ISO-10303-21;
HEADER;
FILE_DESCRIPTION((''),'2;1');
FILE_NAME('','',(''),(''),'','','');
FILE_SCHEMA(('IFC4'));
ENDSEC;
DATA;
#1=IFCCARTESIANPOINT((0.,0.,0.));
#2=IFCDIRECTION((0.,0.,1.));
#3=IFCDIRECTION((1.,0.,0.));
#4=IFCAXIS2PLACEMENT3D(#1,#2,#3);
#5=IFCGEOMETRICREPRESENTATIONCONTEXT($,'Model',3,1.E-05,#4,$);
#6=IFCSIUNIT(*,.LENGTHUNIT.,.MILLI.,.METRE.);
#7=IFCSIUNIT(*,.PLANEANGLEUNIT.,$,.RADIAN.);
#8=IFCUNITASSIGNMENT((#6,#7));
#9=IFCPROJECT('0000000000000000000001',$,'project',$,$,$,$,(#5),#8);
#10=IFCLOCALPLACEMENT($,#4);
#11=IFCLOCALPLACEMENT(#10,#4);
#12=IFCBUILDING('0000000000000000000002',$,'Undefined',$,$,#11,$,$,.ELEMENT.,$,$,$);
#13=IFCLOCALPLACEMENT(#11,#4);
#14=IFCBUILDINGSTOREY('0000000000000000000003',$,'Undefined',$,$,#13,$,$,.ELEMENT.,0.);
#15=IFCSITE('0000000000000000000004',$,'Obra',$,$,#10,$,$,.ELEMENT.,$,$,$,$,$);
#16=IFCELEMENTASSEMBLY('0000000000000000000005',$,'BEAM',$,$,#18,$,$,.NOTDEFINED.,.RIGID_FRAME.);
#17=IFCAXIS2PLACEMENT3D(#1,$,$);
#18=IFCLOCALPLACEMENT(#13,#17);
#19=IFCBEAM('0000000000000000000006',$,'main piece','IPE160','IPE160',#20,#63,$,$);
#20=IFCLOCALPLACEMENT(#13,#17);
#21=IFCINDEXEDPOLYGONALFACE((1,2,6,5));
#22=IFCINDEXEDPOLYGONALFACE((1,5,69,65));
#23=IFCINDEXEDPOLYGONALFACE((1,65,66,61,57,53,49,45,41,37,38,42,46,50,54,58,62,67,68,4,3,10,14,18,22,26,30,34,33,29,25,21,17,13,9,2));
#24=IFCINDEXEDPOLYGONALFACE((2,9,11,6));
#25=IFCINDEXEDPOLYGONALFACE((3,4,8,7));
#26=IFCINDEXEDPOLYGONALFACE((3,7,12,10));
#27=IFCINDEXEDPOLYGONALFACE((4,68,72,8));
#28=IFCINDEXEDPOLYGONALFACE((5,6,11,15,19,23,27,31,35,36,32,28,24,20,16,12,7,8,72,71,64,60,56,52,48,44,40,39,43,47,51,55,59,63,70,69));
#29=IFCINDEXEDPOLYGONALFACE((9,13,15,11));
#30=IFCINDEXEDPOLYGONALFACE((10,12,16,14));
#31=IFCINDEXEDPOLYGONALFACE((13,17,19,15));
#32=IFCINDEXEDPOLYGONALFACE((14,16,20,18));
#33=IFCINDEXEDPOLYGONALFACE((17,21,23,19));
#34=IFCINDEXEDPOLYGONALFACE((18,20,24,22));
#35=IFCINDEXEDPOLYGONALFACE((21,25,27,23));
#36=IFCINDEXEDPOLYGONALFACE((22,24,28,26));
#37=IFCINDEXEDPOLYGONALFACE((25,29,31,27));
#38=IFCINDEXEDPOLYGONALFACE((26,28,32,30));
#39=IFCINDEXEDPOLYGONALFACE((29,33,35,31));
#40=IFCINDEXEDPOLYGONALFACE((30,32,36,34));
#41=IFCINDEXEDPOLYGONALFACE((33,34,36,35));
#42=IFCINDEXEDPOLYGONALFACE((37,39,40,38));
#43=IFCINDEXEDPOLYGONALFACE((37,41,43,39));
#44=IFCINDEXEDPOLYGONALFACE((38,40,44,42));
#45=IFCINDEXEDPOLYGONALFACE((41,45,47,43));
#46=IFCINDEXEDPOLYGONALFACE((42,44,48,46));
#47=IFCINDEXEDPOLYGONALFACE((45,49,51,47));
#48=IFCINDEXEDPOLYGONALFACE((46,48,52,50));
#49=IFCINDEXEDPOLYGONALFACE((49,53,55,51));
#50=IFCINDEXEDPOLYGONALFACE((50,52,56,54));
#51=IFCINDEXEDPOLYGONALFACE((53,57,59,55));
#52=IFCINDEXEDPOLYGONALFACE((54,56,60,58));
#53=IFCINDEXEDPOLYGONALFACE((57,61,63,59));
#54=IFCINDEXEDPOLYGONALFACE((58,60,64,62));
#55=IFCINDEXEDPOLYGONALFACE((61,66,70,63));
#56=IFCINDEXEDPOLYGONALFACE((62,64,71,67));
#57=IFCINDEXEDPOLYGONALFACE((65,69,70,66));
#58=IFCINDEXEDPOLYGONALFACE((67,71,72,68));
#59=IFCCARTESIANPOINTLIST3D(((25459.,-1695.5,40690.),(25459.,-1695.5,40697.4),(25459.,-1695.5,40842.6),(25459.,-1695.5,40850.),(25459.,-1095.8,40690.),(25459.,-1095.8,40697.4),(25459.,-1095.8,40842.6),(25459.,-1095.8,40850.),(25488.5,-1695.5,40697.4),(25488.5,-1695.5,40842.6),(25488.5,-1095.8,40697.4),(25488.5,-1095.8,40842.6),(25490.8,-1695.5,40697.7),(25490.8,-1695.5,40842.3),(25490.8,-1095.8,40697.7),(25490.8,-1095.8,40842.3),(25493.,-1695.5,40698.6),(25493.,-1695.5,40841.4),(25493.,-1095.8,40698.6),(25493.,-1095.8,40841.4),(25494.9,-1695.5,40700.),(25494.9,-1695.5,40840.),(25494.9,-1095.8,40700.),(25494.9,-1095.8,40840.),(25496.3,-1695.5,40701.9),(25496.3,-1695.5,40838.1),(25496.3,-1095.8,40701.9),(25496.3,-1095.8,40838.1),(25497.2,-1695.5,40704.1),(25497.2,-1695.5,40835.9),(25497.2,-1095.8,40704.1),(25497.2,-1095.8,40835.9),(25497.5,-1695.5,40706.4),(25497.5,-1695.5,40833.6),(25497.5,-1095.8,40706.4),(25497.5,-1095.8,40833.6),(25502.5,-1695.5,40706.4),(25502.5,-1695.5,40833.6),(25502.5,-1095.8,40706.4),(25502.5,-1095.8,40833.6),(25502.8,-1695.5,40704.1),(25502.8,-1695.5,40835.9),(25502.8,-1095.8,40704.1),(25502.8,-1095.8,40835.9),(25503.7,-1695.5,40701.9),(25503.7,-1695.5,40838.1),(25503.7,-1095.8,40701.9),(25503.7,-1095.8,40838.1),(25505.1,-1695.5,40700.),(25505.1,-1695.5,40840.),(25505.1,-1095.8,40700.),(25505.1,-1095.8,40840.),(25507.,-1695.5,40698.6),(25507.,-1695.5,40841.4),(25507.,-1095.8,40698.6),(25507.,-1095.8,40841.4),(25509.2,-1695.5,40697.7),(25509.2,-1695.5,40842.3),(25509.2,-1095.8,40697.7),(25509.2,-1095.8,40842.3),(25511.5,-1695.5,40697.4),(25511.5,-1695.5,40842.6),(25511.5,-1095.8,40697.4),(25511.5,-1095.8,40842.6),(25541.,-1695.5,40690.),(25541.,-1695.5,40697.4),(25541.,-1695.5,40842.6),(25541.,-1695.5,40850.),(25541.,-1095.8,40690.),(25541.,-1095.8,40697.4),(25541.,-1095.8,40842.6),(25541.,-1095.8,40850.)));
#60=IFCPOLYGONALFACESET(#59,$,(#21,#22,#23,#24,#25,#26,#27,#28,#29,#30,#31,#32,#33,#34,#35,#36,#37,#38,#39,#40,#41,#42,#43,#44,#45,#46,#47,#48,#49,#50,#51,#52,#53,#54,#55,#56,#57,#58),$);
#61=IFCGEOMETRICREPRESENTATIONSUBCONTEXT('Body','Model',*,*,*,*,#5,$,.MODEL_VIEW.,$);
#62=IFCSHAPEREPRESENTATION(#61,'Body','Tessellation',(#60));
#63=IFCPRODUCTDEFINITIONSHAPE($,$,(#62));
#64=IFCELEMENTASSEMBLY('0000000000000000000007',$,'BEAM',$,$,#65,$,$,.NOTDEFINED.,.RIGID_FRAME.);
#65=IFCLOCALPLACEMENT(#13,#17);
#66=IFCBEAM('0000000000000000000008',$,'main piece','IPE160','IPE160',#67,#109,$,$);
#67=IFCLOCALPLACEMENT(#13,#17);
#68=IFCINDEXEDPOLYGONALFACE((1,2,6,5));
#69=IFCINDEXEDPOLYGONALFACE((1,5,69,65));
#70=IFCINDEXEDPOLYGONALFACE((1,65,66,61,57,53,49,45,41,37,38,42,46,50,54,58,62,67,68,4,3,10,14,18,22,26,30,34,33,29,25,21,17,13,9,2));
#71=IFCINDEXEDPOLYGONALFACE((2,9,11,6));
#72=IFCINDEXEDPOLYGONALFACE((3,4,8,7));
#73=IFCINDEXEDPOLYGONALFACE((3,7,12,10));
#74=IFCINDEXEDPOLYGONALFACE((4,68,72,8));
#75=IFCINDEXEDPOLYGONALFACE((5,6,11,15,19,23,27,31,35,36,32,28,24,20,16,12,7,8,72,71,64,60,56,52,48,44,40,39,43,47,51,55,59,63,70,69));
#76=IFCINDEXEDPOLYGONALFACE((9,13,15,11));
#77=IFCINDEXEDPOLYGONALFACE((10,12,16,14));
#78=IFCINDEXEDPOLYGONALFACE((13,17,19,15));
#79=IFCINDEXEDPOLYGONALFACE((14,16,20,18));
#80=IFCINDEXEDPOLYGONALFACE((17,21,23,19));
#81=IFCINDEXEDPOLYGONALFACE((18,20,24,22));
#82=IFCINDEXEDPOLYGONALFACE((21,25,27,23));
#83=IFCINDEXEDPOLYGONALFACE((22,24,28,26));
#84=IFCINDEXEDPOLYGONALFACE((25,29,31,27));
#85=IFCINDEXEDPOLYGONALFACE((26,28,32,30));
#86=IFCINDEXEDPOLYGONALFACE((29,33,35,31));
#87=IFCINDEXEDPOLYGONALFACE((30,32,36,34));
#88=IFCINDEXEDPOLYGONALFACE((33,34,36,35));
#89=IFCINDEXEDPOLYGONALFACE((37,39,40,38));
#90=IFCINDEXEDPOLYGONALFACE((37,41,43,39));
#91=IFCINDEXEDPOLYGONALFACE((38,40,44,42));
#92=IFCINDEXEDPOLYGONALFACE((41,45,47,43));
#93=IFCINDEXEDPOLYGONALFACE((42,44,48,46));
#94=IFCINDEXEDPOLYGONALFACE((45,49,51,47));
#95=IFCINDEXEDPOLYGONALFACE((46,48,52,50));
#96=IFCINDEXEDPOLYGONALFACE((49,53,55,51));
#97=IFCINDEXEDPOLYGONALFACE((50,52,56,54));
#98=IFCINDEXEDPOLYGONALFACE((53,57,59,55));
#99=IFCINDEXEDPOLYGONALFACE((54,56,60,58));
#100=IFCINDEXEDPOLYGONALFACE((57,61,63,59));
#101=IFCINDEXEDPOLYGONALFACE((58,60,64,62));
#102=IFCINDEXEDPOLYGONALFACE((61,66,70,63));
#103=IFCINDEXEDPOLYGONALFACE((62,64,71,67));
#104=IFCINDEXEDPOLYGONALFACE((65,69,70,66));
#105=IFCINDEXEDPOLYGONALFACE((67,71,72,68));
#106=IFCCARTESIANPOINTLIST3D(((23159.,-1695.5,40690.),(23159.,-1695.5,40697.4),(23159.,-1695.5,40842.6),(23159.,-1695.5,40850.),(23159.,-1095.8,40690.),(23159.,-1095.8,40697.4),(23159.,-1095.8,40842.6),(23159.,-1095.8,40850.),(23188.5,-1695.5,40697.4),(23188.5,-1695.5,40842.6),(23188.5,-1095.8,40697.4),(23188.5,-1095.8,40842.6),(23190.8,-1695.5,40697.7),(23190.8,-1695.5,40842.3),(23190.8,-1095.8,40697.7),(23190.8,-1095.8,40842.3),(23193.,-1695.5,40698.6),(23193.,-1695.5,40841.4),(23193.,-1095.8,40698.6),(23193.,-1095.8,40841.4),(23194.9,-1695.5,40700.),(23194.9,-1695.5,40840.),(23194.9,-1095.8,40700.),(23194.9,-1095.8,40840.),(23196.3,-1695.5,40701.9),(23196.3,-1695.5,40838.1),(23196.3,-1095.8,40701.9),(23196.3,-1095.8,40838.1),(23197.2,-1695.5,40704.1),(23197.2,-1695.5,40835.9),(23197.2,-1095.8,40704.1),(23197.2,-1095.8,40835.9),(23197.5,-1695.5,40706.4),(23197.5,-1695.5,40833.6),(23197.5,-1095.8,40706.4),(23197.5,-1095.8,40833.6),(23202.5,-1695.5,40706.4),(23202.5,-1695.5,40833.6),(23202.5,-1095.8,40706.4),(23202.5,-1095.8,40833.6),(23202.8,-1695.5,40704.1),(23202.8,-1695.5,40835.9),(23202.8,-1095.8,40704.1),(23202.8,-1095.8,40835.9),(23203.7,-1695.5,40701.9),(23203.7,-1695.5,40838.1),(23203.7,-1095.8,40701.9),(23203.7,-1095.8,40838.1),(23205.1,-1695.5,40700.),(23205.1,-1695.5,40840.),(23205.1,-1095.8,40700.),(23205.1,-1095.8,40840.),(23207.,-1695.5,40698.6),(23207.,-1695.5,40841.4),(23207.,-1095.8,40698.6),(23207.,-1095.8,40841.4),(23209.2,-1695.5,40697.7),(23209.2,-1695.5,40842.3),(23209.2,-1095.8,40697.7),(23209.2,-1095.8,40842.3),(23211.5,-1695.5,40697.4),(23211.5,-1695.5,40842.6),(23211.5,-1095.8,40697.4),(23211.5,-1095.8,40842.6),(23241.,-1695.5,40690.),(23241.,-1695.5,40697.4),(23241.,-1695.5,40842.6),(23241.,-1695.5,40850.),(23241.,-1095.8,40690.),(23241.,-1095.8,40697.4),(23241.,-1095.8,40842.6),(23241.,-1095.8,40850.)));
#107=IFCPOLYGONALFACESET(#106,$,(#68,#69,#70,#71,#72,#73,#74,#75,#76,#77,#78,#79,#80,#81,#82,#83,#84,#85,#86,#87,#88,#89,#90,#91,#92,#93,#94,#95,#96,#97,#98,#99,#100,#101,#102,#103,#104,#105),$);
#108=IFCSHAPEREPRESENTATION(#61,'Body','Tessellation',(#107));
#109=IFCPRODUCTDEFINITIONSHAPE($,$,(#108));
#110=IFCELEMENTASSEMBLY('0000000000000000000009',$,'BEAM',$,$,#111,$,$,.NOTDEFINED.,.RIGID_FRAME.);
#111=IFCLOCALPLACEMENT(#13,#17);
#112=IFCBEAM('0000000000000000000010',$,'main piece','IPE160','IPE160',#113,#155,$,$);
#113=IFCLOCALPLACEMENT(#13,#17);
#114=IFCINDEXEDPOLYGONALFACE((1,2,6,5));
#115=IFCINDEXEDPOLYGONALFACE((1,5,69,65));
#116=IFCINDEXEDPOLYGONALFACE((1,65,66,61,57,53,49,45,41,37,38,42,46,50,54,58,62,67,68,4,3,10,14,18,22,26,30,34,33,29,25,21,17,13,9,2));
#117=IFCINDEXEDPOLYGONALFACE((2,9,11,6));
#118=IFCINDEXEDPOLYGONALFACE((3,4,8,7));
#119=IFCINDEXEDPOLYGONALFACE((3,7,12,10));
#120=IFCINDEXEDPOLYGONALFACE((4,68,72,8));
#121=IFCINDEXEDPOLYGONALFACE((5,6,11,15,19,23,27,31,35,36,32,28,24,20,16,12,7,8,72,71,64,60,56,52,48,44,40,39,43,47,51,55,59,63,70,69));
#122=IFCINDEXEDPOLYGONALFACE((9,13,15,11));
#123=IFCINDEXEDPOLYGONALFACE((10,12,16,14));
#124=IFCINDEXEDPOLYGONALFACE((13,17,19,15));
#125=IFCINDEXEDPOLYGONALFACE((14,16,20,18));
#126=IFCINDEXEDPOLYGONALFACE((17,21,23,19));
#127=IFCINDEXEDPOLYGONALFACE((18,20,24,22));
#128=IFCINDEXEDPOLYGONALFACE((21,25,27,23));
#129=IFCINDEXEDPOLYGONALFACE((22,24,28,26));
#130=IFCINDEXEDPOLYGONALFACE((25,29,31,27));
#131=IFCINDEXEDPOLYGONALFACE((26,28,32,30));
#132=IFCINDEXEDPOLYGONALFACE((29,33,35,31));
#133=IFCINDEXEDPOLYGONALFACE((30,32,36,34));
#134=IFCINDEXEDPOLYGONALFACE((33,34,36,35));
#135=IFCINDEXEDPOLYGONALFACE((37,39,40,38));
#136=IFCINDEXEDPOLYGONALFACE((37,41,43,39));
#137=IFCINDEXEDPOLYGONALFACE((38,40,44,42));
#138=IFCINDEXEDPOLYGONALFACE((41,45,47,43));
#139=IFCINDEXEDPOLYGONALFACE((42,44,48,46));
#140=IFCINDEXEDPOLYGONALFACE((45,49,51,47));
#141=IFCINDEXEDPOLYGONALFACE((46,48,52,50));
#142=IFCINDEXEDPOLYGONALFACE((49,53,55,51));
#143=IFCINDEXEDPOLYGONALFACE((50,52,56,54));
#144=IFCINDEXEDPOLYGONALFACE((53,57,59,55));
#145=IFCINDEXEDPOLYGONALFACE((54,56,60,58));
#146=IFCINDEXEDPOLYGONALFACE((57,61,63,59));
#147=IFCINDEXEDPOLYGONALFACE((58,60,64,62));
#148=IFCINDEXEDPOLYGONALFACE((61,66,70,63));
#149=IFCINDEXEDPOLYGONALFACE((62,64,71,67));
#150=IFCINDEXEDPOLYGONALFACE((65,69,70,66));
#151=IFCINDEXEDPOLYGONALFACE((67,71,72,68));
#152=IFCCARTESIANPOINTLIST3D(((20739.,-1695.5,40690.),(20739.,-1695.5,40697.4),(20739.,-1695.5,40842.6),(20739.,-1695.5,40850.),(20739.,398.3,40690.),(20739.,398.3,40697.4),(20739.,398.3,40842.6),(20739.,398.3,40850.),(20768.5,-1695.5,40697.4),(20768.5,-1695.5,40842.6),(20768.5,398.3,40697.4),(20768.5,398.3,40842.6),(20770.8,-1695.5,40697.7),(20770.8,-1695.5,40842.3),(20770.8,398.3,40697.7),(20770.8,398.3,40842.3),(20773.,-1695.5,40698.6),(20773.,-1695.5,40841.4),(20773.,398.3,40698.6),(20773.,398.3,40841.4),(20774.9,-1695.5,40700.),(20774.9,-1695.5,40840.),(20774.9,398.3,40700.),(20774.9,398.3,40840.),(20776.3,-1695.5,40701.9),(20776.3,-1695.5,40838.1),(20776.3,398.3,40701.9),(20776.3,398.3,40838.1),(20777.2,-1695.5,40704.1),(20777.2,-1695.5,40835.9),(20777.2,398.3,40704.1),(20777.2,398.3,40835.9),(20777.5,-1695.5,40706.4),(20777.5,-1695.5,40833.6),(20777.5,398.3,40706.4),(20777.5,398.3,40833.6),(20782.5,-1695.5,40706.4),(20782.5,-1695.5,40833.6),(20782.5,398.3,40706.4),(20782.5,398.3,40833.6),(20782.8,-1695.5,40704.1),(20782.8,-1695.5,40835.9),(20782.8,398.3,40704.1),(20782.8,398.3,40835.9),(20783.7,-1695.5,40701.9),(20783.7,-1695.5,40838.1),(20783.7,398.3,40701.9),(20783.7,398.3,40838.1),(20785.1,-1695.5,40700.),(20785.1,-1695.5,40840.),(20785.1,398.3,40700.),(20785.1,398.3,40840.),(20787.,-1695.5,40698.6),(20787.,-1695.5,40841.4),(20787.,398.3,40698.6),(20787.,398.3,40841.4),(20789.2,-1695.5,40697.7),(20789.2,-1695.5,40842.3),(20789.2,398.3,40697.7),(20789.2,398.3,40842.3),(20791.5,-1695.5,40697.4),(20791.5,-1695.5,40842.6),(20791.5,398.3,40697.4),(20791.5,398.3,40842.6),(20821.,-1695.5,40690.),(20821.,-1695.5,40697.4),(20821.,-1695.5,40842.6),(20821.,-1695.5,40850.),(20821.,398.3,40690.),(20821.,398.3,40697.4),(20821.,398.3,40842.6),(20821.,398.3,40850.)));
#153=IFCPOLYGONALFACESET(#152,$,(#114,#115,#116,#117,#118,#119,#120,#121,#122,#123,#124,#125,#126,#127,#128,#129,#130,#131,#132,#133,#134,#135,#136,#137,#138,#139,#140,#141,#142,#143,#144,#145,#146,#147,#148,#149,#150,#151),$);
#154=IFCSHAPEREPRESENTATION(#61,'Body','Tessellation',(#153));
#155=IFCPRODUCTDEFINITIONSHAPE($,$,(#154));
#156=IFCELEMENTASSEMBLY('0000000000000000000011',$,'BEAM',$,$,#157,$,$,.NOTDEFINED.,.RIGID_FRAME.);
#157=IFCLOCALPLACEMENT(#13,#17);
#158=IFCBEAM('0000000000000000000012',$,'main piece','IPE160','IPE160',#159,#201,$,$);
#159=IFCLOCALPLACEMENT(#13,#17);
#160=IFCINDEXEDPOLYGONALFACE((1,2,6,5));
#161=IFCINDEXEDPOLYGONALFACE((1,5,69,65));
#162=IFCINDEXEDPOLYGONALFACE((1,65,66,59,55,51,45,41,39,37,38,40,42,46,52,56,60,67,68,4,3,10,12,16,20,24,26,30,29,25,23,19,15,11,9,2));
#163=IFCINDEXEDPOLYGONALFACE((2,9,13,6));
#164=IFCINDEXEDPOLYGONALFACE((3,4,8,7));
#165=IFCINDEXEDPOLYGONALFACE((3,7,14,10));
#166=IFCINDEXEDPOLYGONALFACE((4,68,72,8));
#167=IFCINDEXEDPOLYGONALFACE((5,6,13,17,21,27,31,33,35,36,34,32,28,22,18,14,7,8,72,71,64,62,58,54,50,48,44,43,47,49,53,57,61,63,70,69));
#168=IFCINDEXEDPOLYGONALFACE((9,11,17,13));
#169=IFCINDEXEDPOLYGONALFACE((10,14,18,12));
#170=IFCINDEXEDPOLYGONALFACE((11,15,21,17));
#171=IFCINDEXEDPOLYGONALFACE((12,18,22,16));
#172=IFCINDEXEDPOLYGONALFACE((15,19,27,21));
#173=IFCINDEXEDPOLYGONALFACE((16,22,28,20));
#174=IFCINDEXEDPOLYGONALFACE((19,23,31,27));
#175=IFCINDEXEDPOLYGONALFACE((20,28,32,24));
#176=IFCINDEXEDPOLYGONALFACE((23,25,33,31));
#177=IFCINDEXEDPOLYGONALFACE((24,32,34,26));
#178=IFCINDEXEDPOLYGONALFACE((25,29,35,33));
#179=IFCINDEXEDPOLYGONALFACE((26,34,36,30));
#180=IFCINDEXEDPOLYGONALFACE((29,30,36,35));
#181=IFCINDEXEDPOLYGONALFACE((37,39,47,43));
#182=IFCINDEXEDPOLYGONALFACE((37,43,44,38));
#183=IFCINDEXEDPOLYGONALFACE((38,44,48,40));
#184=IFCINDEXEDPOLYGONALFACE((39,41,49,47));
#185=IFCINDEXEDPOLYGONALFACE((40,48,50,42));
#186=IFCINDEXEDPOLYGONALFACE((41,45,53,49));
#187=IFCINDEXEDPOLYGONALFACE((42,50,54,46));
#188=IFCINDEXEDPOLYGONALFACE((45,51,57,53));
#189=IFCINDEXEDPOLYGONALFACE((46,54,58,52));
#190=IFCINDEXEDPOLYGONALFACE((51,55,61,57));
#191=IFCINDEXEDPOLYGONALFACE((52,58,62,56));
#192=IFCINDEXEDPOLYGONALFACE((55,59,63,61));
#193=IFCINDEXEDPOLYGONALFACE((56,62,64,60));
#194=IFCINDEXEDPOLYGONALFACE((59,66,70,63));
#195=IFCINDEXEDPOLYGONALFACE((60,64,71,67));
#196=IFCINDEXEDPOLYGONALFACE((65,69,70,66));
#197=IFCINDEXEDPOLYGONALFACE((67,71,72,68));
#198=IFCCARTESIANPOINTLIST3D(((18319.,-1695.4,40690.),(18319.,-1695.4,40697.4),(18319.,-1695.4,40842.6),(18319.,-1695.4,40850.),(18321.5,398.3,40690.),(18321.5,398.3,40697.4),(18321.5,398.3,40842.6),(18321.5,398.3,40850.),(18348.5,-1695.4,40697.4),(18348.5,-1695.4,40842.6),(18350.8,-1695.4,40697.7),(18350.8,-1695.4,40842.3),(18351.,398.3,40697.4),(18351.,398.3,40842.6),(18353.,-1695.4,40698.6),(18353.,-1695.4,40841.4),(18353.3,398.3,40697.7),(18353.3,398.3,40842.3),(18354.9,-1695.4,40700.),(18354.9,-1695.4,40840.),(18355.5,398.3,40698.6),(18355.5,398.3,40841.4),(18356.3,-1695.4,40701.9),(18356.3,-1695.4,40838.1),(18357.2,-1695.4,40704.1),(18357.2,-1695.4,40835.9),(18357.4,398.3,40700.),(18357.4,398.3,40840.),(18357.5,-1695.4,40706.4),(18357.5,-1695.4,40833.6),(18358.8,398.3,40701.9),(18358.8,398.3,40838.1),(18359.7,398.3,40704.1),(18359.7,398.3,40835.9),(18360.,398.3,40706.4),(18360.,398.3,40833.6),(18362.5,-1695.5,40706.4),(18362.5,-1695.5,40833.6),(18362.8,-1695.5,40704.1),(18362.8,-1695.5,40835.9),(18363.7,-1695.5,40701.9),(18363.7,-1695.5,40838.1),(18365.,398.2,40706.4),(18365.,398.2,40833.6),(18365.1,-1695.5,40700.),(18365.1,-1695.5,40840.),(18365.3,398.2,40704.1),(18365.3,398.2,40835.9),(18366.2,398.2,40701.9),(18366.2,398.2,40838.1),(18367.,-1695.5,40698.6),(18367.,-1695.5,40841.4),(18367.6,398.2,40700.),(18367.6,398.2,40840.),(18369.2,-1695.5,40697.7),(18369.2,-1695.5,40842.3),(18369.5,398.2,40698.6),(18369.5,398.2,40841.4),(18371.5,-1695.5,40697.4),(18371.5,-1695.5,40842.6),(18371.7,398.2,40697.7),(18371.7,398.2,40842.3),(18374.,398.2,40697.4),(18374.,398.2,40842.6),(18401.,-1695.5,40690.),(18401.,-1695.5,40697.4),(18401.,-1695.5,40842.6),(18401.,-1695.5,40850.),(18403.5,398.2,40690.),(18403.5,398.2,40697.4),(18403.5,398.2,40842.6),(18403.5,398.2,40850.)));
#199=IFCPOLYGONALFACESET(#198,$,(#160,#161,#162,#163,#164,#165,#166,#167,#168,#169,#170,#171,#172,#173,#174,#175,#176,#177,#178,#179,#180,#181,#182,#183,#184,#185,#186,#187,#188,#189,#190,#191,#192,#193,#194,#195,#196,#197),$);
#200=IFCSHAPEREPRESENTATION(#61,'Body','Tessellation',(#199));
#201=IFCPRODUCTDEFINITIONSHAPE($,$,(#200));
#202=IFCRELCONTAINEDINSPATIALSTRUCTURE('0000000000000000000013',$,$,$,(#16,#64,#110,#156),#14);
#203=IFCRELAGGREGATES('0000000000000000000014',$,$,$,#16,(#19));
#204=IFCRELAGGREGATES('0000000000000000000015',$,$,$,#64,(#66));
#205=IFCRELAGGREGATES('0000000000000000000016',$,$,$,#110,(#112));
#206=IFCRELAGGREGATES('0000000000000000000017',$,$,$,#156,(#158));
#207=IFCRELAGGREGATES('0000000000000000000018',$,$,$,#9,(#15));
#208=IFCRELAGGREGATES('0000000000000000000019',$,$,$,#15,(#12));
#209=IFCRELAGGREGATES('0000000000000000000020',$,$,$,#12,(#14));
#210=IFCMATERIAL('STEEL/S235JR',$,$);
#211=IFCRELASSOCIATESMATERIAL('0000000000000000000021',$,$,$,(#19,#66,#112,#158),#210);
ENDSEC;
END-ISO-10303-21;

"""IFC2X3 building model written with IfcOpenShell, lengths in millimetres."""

from ifc_helpers import new_model, si_unit, frame, origin_with_axes, origin_2d_with_axis, place, context, subcontext, project, spatial, i_section, extrude, material, element, aggregate, save


model = new_model("IFC2X3")

# Units and contexts
model_context = context("Model", 3, precision=1e-05, world=origin_with_axes())
body_context = subcontext(model_context, "Body", "Model", "MODEL_VIEW")
ifc_project = project(units=[si_unit("LENGTHUNIT", "METRE", prefix="MILLI"), si_unit("PLANEANGLEUNIT", "RADIAN")], contexts=[model_context])

# Site, building, storey
site_placement = place(None, origin_with_axes())
site = spatial("IfcSite", under=ifc_project, at=site_placement, Name="Obra", CompositionType="ELEMENT")
building_placement = place(site_placement, origin_with_axes())
building = spatial("IfcBuilding", under=site, at=building_placement, Name="Undefined", CompositionType="ELEMENT")
storey_placement = place(building_placement, origin_with_axes())
storey = spatial("IfcBuildingStorey", under=building, at=storey_placement, Name="Undefined", CompositionType="ELEMENT", Elevation=0.0)

# Shared definitions
ifc_material_1 = material(Name="STEEL/S235JR")

# Element assemblies, beams
assembly_1_placement = place(storey_placement, origin_with_axes())
assembly_1 = element("IfcElementAssembly", 1, at=assembly_1_placement, inside=storey, Name="BEAM", AssemblyPlace="NOTDEFINED", PredefinedType="RIGID_FRAME")
beam_1_placement = place(assembly_1_placement, frame((25500.0, -1095.8, 40770.0), z_axis=(0.0, 0.0, 1.0), x_axis=(0.0, -1.0, 0.0)))
beam_1 = element("IfcBeam", 2, at=beam_1_placement, material=ifc_material_1, Name="main piece", Description="IPE160", ObjectType="IPE160", context=body_context, shape_type="SweptSolid", body=[
    extrude(i_section(OverallWidth=82.0, OverallDepth=160.0, WebThickness=5.0, FlangeThickness=7.4, FilletRadius=9.0, at=origin_2d_with_axis()), frame((599.7, 0.0, 0.0), z_axis=(-1.0, 0.0, 0.0), x_axis=(0.0, -1.0, 0.0)), (0.0, 0.0, 1.0), 599.7),
])
aggregate(assembly_1, [beam_1])
assembly_2_placement = place(storey_placement, origin_with_axes())
assembly_2 = element("IfcElementAssembly", 3, at=assembly_2_placement, inside=storey, Name="BEAM", AssemblyPlace="NOTDEFINED", PredefinedType="RIGID_FRAME")
beam_2_placement = place(assembly_2_placement, frame((23200.0, -1695.5, 40770.0), z_axis=(0.0, 0.0, 1.0), x_axis=(0.0, 1.0, 0.0)))
beam_2 = element("IfcBeam", 4, at=beam_2_placement, material=ifc_material_1, Name="main piece", Description="IPE160", ObjectType="IPE160", context=body_context, shape_type="SweptSolid", body=[
    extrude(i_section(OverallWidth=82.0, OverallDepth=160.0, WebThickness=5.0, FlangeThickness=7.4, FilletRadius=9.0, at=origin_2d_with_axis()), frame((599.7, 0.0, 0.0), z_axis=(-1.0, 0.0, 0.0), x_axis=(0.0, -1.0, 0.0)), (0.0, 0.0, 1.0), 599.7),
])
aggregate(assembly_2, [beam_2])
assembly_3_placement = place(storey_placement, origin_with_axes())
assembly_3 = element("IfcElementAssembly", 5, at=assembly_3_placement, inside=storey, Name="BEAM", AssemblyPlace="NOTDEFINED", PredefinedType="RIGID_FRAME")
beam_3_placement = place(assembly_3_placement, frame((20780.0, 398.3, 40770.0), z_axis=(0.0, 0.0, 1.0), x_axis=(0.0, -1.0, 0.0)))
beam_3 = element("IfcBeam", 6, at=beam_3_placement, material=ifc_material_1, Name="main piece", Description="IPE160", ObjectType="IPE160", context=body_context, shape_type="SweptSolid", body=[
    extrude(i_section(OverallWidth=82.0, OverallDepth=160.0, WebThickness=5.0, FlangeThickness=7.4, FilletRadius=9.0, at=origin_2d_with_axis()), frame((2093.8, 0.0, 0.0), z_axis=(-1.0, 0.0, 0.0), x_axis=(0.0, -1.0, 0.0)), (0.0, 0.0, 1.0), 2093.8),
])
aggregate(assembly_3, [beam_3])
assembly_4_placement = place(storey_placement, origin_with_axes())
assembly_4 = element("IfcElementAssembly", 7, at=assembly_4_placement, inside=storey, Name="BEAM", AssemblyPlace="NOTDEFINED", PredefinedType="RIGID_FRAME")
beam_4_placement = place(assembly_4_placement, frame((18360.0, -1695.5, 40770.0), z_axis=(0.0, 0.0, 1.0), x_axis=(0.001194, 0.999999, 0.0)))
beam_4 = element("IfcBeam", 8, at=beam_4_placement, material=ifc_material_1, Name="main piece", Description="IPE160", ObjectType="IPE160", context=body_context, shape_type="SweptSolid", body=[
    extrude(i_section(OverallWidth=82.0, OverallDepth=160.0, WebThickness=5.0, FlangeThickness=7.4, FilletRadius=9.0, at=origin_2d_with_axis()), frame((2093.7, 0.0, 0.0), z_axis=(-1.0, 0.0, 0.0), x_axis=(0.0, -1.0, 0.0)), (0.0, 0.0, 1.0), 2093.7),
])
aggregate(assembly_4, [beam_4])

save(model, "model.ifc")
